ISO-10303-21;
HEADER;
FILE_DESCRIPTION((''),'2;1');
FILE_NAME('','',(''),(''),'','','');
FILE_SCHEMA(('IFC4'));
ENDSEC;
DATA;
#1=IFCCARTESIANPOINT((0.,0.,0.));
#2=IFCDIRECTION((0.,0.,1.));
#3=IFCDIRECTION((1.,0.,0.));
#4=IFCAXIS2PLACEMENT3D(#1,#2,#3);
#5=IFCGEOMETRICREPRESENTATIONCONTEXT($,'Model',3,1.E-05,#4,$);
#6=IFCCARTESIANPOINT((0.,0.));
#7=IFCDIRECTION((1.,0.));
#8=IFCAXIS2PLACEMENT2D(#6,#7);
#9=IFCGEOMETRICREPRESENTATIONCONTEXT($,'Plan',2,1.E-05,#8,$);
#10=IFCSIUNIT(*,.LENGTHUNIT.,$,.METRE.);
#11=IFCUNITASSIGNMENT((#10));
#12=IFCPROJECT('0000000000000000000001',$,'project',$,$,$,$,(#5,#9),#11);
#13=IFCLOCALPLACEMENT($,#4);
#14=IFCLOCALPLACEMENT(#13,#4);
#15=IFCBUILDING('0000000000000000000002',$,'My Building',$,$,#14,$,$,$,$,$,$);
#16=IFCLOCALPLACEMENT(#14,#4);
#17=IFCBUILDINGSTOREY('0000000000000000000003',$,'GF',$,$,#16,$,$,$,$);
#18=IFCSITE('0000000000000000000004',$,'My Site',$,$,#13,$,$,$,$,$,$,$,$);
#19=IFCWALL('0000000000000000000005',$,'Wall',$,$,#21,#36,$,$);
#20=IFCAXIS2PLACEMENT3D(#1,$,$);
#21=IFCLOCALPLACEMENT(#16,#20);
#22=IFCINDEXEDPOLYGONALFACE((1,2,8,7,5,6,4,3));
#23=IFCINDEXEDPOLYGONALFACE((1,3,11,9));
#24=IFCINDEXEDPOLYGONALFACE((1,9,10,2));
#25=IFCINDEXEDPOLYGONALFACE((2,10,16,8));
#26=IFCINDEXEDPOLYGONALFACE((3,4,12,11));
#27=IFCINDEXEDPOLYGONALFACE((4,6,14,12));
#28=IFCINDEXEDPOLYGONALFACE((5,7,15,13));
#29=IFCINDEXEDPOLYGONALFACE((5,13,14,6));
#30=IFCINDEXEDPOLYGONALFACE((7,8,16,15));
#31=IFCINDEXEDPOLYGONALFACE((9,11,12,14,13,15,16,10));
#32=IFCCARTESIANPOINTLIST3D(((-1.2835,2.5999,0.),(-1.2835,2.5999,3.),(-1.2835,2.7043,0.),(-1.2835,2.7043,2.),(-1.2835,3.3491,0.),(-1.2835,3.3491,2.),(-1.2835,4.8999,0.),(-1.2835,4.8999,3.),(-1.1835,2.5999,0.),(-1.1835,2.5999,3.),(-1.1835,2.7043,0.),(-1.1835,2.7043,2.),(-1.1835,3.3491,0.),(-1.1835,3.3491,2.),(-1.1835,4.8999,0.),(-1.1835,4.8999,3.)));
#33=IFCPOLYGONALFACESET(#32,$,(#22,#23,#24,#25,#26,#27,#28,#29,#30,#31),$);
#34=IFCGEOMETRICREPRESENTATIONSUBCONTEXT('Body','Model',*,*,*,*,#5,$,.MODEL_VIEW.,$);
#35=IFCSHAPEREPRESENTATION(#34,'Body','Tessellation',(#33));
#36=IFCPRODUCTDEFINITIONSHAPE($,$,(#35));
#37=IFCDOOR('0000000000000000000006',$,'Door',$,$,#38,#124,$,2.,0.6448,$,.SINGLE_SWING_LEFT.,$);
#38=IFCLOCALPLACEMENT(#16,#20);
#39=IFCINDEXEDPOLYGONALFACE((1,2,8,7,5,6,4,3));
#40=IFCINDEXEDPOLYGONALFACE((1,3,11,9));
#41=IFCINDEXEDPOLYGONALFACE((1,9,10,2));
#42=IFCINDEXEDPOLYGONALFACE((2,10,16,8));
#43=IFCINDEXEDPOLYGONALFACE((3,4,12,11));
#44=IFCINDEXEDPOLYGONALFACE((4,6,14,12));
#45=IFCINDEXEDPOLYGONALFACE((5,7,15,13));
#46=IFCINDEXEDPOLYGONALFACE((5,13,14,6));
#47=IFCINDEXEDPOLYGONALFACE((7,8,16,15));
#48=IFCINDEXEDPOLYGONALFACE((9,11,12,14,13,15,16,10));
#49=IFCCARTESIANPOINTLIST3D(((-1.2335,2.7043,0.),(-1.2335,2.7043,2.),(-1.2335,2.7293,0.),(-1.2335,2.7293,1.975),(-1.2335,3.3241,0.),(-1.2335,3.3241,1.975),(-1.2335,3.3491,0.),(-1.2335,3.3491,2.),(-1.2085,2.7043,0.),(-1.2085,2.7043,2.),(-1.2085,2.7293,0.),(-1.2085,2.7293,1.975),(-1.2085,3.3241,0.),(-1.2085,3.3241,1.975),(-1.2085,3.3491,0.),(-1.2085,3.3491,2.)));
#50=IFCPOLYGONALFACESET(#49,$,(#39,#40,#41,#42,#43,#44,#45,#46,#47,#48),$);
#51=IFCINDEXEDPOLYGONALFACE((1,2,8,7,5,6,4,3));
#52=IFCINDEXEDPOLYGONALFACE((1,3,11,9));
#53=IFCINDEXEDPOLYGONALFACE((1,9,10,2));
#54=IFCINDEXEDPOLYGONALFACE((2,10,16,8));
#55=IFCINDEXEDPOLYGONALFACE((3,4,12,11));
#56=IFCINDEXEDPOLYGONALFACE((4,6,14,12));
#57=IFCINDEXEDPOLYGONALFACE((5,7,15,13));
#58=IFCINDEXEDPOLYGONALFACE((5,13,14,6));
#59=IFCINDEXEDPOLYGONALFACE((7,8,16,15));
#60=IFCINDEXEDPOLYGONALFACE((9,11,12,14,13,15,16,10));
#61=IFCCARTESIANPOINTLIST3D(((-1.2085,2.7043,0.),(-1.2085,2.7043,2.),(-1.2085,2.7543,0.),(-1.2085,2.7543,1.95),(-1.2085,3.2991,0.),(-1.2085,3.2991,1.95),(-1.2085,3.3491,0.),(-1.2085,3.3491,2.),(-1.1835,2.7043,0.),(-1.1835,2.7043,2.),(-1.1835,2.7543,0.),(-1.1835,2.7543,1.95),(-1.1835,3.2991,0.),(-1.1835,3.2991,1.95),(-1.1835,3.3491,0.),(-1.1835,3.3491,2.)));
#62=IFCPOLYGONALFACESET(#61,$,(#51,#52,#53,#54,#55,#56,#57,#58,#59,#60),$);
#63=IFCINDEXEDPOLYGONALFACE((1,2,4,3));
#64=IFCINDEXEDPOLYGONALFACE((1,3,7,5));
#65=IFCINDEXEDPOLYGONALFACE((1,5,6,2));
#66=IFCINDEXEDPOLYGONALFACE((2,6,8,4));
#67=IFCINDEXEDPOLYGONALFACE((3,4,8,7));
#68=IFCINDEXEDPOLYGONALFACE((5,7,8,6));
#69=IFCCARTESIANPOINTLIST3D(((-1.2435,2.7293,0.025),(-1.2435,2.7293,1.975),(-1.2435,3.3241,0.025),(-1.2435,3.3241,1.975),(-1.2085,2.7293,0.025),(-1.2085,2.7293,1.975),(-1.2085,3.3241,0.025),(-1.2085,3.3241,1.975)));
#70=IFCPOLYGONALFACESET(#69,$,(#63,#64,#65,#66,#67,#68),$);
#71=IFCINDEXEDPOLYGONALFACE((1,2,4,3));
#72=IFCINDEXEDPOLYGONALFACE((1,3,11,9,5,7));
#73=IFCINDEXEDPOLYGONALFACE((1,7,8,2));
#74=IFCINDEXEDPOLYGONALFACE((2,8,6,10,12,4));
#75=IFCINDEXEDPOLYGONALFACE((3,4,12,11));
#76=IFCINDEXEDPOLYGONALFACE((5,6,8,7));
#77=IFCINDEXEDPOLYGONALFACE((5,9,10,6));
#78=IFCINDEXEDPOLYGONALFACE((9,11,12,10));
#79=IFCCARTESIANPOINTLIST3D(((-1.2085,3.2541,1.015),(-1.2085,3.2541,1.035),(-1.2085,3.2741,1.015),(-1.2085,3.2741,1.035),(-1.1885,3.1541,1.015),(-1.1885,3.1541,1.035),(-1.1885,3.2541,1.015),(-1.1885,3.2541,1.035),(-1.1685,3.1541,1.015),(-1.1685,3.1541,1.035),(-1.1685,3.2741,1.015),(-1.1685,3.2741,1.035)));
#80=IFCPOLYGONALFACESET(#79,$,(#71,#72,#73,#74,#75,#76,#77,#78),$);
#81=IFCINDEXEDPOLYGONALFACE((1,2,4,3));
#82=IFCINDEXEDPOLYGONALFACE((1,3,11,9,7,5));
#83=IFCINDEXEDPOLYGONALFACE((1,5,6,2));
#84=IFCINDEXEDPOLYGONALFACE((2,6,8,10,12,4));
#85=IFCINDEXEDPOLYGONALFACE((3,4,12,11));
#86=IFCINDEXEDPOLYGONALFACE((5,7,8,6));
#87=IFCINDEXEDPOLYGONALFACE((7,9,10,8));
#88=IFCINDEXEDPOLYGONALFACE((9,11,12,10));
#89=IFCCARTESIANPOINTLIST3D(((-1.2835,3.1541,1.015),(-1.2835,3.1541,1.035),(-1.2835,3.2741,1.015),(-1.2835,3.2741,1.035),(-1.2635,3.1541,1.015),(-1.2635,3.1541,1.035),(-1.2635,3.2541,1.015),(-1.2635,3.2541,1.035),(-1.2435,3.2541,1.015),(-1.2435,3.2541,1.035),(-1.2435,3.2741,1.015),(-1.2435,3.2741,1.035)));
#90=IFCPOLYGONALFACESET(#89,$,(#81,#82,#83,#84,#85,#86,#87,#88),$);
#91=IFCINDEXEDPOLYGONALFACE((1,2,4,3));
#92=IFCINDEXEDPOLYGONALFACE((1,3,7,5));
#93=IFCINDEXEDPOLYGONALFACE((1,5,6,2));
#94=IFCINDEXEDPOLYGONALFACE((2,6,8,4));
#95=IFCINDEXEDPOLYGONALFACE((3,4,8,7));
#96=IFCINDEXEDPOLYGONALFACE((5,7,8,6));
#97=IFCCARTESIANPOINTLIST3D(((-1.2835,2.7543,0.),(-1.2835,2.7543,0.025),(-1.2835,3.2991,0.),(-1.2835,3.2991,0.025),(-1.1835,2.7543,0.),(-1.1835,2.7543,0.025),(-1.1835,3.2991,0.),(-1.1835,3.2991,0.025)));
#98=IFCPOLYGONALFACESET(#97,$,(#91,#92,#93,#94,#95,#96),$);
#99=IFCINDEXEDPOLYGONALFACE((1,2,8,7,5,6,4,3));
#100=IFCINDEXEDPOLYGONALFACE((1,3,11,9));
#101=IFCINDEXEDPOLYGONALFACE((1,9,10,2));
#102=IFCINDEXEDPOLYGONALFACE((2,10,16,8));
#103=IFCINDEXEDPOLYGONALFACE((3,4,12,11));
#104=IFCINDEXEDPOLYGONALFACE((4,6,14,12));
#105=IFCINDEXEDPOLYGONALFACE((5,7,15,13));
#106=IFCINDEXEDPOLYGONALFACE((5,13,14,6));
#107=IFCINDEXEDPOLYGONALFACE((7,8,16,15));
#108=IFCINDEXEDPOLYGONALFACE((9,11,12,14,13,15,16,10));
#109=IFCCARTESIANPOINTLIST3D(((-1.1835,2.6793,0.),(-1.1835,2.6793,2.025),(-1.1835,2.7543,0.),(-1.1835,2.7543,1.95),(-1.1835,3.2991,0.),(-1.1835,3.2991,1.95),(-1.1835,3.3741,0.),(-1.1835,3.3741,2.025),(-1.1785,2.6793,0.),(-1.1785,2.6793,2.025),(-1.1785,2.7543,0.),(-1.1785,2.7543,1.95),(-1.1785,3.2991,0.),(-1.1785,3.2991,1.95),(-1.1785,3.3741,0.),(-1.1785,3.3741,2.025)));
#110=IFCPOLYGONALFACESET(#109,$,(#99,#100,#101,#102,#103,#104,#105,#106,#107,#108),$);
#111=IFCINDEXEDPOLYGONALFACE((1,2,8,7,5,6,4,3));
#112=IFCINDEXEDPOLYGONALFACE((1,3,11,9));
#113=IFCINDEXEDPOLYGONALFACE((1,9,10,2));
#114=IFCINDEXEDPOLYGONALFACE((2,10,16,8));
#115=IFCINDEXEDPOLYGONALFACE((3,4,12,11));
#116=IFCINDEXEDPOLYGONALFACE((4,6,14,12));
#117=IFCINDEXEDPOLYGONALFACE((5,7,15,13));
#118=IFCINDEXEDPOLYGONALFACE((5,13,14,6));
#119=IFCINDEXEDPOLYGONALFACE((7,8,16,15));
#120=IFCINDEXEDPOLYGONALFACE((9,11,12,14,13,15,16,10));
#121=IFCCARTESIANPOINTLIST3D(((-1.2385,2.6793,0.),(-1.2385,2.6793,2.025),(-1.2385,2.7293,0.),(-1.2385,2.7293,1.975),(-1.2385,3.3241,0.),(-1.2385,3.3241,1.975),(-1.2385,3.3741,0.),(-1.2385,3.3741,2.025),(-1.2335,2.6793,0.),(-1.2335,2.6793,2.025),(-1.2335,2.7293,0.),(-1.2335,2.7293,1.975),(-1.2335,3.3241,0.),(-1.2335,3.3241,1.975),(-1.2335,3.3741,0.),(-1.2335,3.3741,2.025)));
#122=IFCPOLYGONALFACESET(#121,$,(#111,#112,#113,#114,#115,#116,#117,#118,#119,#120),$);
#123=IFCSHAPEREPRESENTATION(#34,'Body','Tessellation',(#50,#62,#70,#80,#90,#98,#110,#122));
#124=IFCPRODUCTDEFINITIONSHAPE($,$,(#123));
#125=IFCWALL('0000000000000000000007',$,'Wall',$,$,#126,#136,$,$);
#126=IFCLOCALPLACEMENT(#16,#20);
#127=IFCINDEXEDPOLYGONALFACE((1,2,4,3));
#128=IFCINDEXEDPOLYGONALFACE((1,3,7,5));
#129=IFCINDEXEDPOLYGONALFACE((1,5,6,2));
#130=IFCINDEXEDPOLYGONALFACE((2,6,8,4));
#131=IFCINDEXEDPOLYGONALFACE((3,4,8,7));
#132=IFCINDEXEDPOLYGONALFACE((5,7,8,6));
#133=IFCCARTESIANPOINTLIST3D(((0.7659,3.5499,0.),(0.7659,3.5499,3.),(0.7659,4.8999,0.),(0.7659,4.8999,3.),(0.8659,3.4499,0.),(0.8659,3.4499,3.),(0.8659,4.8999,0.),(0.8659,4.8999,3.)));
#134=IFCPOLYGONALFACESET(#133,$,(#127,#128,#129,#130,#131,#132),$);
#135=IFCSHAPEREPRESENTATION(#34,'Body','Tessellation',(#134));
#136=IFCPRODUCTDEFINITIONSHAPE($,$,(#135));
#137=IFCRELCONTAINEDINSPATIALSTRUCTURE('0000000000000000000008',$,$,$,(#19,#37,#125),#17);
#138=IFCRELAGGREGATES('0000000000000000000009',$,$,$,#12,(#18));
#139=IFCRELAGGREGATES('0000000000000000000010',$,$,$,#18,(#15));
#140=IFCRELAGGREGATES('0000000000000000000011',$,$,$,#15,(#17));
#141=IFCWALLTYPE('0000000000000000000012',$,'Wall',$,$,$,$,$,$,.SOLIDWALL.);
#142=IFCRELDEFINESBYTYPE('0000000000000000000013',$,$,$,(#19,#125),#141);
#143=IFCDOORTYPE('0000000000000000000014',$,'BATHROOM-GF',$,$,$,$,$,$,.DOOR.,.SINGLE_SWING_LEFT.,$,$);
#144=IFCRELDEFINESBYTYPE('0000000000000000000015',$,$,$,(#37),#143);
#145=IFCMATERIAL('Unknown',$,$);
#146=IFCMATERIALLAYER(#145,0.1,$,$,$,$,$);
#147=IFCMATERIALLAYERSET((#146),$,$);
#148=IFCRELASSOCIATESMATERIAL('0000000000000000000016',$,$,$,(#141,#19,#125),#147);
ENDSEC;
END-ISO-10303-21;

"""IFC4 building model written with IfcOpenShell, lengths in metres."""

from ifc_helpers import new_model, entity, si_unit, frame, origin_with_axes, origin_2d_with_axis, place, context, subcontext, project, spatial, line, indexed_curve, outline, extrude, shape, source, transform, mapped, material, layer, layer_set, layer_usage, type_object, type_shapes, element, fill, save


model = new_model("IFC4")

# Units and contexts
model_context = context("Model", 3, precision=1e-05, world=origin_with_axes())
plan_context = context("Plan", 2, precision=1e-05, world=origin_2d_with_axis())
body_context_1 = subcontext(model_context, "Body", "Model", "MODEL_VIEW")
body_context_2 = subcontext(plan_context, "Body", "Plan", "PLAN_VIEW")
ifc_project = project(units=[si_unit("LENGTHUNIT", "METRE")], contexts=[model_context, plan_context])

# Site, building, storey
site_placement = place(None, origin_with_axes())
site = spatial("IfcSite", under=ifc_project, at=site_placement, Name="My Site")
building_placement = place(site_placement, origin_with_axes())
building = spatial("IfcBuilding", under=site, at=building_placement, Name="My Building")
storey_placement = place(building_placement, origin_with_axes())
storey = spatial("IfcBuildingStorey", under=building, at=storey_placement, Name="GF")

# Shared definitions
ifc_material_1 = material(Name="Unknown")

# Shared definitions
ifc_layer_1 = layer(ifc_material_1, 0.1)
ifc_layer_set_1 = layer_set([ifc_layer_1])
wall_type = type_object("IfcWallType", Name="Wall", PredefinedType="SOLIDWALL", material=ifc_layer_set_1)

# Wall, opening, door
ifc_layer_usage_1 = layer_usage(ifc_layer_set_1, "AXIS2", "POSITIVE", 0.0)
wall_1_placement = place(storey_placement, frame((-1.1835, 2.5999, 0.0), z_axis=(0.0, 0.0, 1.0), x_axis=(0.0, 1.0, 0.0)))
wall_1 = element("IfcWall", 1, at=wall_1_placement, inside=storey, type_object=wall_type, material=ifc_layer_usage_1, Name="Wall", context=body_context_1, shape_type="SweptSolid", body=[
    extrude(outline(indexed_curve([(0.0, 0.0), (0.0, 0.1), (2.3, 0.1), (2.3, 0.0)], segments=[line(1, 2, 3, 4, 1)])), origin_with_axes(), (0.0, 0.0, 1.0), 3.0),
])
shared_shape_1 = source(origin_with_axes(), body_context_1, "Body", "SweptSolid", [
    extrude(outline(indexed_curve([(0.0, 0.0), (0.6448, 0.0), (0.6448, 2.0), (0.0, 2.0)], segments=[line(1, 2, 3, 4, 1)])), frame((0.0, -0.6, 0.0), z_axis=(0.0, -1.0, 0.0), x_axis=(1.0, 0.0, 0.0)), (0.0, 0.0, -1.0), 1.2),
])
opening_1_placement = place(wall_1_placement, frame((0.1044, 0.0, 0.0), z_axis=(0.0, 0.0, 1.0), x_axis=(1.0, 0.0, 0.0)))
opening_1 = element("IfcOpeningElement", 2, at=opening_1_placement, cuts=wall_1, PredefinedType="OPENING", context=body_context_1, shape_type="MappedRepresentation", body=[
    mapped(shared_shape_1, transform((0.0, 0.0, 0.0), x_axis=(1.0, 0.0, 0.0), y_axis=(0.0, 1.0, 0.0), z_axis=(0.0, 0.0, 1.0), scale=1.0)),
])
door_type_1 = type_object("IfcDoorType", Name="BATHROOM-GF", OperationType="SINGLE_SWING_LEFT", PredefinedType="DOOR")
shared_shape_2 = source(origin_with_axes(), body_context_1, "Body", "SweptSolid", [
    extrude(outline(indexed_curve([(0.0, 0.0), (0.0, 2.0), (0.6448, 2.0), (0.6448, 0.0), (0.6198, 0.0), (0.6198, 1.975), (0.025, 1.975), (0.025, 0.0)], segments=[line(1, 2, 3, 4, 5, 6, 7, 8, 1)])), frame((0.0, 0.025, 0.0), z_axis=(0.0, -1.0, 0.0), x_axis=(1.0, 0.0, 0.0)), (0.0, 0.0, -1.0), 0.025),
    extrude(outline(indexed_curve([(0.0, 0.0), (0.0, 2.0), (0.6448, 2.0), (0.6448, 0.0), (0.5948, 0.0), (0.5948, 1.95), (0.05, 1.95), (0.05, 0.0)], segments=[line(1, 2, 3, 4, 5, 6, 7, 8, 1)])), frame((0.0, 0.0, 0.0), z_axis=(0.0, -1.0, 0.0), x_axis=(1.0, 0.0, 0.0)), (0.0, 0.0, -1.0), 0.025),
    extrude(outline(indexed_curve([(0.0, 0.0), (0.5948, 0.0), (0.5948, 0.035), (0.0, 0.035)], segments=[line(1, 2, 3, 4, 1)])), frame((0.025, 0.025, 0.025), z_axis=(0.0, 0.0, 1.0), x_axis=(1.0, 0.0, 0.0)), (0.0, 0.0, 1.0), 1.95),
    extrude(outline(indexed_curve([(0.0, 0.0), (0.0, -0.04), (-0.12, -0.04), (-0.12, -0.02), (-0.02, -0.02), (-0.02, 0.0)], segments=[line(1, 2, 3, 4, 5, 6, 1)])), frame((0.5698, 0.025, 1.015), z_axis=(0.0, 0.0, 1.0), x_axis=(1.0, 0.0, 0.0)), (0.0, 0.0, 1.0), 0.02),
    extrude(outline(indexed_curve([(0.0, 0.0), (0.0, 0.04), (-0.12, 0.04), (-0.12, 0.02), (-0.02, 0.02), (-0.02, 0.0)], segments=[line(1, 2, 3, 4, 5, 6, 1)])), frame((0.5698, 0.06, 1.015), z_axis=(0.0, 0.0, 1.0), x_axis=(1.0, 0.0, 0.0)), (0.0, 0.0, 1.0), 0.02),
    extrude(outline(indexed_curve([(0.0, 0.0), (0.5448, 0.0), (0.5448, 0.1), (0.0, 0.1)], segments=[line(1, 2, 3, 4, 1)])), frame((0.05, 0.0, 0.0), z_axis=(0.0, 0.0, 1.0), x_axis=(1.0, 0.0, 0.0)), (0.0, 0.0, 1.0), 0.025),
    extrude(outline(indexed_curve([(0.0, 0.0), (0.0, 2.025), (0.6948, 2.025), (0.6948, 0.0), (0.6198, 0.0), (0.6198, 1.95), (0.075, 1.95), (0.075, 0.0)], segments=[line(1, 2, 3, 4, 5, 6, 7, 8, 1)])), frame((-0.025, -0.005, 0.0), z_axis=(0.0, -1.0, 0.0), x_axis=(1.0, 0.0, 0.0)), (0.0, 0.0, -1.0), 0.005),
    extrude(outline(indexed_curve([(0.0, 0.0), (0.0, 2.025), (0.6948, 2.025), (0.6948, 0.0), (0.6448, 0.0), (0.6448, 1.975), (0.05, 1.975), (0.05, 0.0)], segments=[line(1, 2, 3, 4, 5, 6, 7, 8, 1)])), frame((-0.025, 0.05, 0.0), z_axis=(0.0, -1.0, 0.0), x_axis=(1.0, 0.0, 0.0)), (0.0, 0.0, -1.0), 0.005),
])
shared_shape_3 = source(origin_with_axes(), body_context_2, "Body", "Curve2D", [
    entity("IfcIndexedPolyCurve", entity("IfcCartesianPointList2D", [[0.0, 0.0], [0.0, 0.05], [0.025, 0.05], [0.025, 0.025], [0.05, 0.025], [0.05, 0.0]]), [entity("IfcLineIndex", [1, 2, 3, 4, 5, 6, 1])]),
    entity("IfcIndexedPolyCurve", entity("IfcCartesianPointList2D", [[0.6448, 0.0], [0.6448, 0.05], [0.6198, 0.05], [0.6198, 0.025], [0.5948, 0.025], [0.5948, 0.0]]), [entity("IfcLineIndex", [1, 2, 3, 4, 5, 6, 1])]),
    entity("IfcTrimmedCurve", entity("IfcEllipse", entity("IfcAxis2Placement2D", entity("IfcCartesianPoint", [0.06, 0.05]), entity("IfcDirection", [1.0, 0.0])), 0.5598, 0.5948), [entity("IfcCartesianPoint", [0.6198, 0.05])], [entity("IfcCartesianPoint", [0.06, 0.6448])], True, "CARTESIAN"),
    entity("IfcIndexedPolyCurve", entity("IfcCartesianPointList2D", [[0.025, 0.05], [0.06, 0.05], [0.06, 0.6448], [0.025, 0.6448]]), [entity("IfcLineIndex", [1, 2, 3, 4, 1])]),
])
type_shapes(door_type_1, [shared_shape_2, shared_shape_3])
door_1_placement = place(opening_1_placement, frame((0.0, 0.0, 0.0), z_axis=(0.0, 0.0, 1.0), x_axis=(1.0, 0.0, 0.0)))
door_1 = element("IfcDoor", 3, at=door_1_placement, inside=storey, type_object=door_type_1, Name="Door", OperationType="SINGLE_SWING_LEFT", OverallHeight=2.0, OverallWidth=0.6448, shapes=[
    shape(body_context_1, "Body", "MappedRepresentation", [mapped(shared_shape_2, transform((0.0, 0.0, 0.0), x_axis=(1.0, 0.0, 0.0), y_axis=(0.0, 1.0, 0.0), z_axis=(0.0, 0.0, 1.0), scale=1.0))]),
    shape(body_context_2, "Body", "MappedRepresentation", [mapped(shared_shape_3, transform((0.0, 0.0, 0.0), x_axis=(1.0, 0.0, 0.0), y_axis=(0.0, 1.0, 0.0), z_axis=(0.0, 0.0, 1.0), scale=1.0))]),
])
fill(opening_1, door_1)

# Wall
ifc_layer_usage_2 = layer_usage(ifc_layer_set_1, "AXIS2", "POSITIVE", 0.0)
wall_2_placement = place(storey_placement, frame((0.7659, 4.8999, 0.0), z_axis=(0.0, 0.0, 1.0), x_axis=(0.0, -1.0, 0.0)))
element("IfcWall", 4, at=wall_2_placement, inside=storey, type_object=wall_type, material=ifc_layer_usage_2, Name="Wall", context=body_context_1, shape_type="SweptSolid", body=[
    extrude(outline(indexed_curve([(0.0, 0.0), (0.0, 0.1), (1.45, 0.1), (1.35, 0.0)], segments=[line(1, 2, 3, 4, 1)])), origin_with_axes(), (0.0, 0.0, 1.0), 3.0),
])

save(model, "model.ifc")
